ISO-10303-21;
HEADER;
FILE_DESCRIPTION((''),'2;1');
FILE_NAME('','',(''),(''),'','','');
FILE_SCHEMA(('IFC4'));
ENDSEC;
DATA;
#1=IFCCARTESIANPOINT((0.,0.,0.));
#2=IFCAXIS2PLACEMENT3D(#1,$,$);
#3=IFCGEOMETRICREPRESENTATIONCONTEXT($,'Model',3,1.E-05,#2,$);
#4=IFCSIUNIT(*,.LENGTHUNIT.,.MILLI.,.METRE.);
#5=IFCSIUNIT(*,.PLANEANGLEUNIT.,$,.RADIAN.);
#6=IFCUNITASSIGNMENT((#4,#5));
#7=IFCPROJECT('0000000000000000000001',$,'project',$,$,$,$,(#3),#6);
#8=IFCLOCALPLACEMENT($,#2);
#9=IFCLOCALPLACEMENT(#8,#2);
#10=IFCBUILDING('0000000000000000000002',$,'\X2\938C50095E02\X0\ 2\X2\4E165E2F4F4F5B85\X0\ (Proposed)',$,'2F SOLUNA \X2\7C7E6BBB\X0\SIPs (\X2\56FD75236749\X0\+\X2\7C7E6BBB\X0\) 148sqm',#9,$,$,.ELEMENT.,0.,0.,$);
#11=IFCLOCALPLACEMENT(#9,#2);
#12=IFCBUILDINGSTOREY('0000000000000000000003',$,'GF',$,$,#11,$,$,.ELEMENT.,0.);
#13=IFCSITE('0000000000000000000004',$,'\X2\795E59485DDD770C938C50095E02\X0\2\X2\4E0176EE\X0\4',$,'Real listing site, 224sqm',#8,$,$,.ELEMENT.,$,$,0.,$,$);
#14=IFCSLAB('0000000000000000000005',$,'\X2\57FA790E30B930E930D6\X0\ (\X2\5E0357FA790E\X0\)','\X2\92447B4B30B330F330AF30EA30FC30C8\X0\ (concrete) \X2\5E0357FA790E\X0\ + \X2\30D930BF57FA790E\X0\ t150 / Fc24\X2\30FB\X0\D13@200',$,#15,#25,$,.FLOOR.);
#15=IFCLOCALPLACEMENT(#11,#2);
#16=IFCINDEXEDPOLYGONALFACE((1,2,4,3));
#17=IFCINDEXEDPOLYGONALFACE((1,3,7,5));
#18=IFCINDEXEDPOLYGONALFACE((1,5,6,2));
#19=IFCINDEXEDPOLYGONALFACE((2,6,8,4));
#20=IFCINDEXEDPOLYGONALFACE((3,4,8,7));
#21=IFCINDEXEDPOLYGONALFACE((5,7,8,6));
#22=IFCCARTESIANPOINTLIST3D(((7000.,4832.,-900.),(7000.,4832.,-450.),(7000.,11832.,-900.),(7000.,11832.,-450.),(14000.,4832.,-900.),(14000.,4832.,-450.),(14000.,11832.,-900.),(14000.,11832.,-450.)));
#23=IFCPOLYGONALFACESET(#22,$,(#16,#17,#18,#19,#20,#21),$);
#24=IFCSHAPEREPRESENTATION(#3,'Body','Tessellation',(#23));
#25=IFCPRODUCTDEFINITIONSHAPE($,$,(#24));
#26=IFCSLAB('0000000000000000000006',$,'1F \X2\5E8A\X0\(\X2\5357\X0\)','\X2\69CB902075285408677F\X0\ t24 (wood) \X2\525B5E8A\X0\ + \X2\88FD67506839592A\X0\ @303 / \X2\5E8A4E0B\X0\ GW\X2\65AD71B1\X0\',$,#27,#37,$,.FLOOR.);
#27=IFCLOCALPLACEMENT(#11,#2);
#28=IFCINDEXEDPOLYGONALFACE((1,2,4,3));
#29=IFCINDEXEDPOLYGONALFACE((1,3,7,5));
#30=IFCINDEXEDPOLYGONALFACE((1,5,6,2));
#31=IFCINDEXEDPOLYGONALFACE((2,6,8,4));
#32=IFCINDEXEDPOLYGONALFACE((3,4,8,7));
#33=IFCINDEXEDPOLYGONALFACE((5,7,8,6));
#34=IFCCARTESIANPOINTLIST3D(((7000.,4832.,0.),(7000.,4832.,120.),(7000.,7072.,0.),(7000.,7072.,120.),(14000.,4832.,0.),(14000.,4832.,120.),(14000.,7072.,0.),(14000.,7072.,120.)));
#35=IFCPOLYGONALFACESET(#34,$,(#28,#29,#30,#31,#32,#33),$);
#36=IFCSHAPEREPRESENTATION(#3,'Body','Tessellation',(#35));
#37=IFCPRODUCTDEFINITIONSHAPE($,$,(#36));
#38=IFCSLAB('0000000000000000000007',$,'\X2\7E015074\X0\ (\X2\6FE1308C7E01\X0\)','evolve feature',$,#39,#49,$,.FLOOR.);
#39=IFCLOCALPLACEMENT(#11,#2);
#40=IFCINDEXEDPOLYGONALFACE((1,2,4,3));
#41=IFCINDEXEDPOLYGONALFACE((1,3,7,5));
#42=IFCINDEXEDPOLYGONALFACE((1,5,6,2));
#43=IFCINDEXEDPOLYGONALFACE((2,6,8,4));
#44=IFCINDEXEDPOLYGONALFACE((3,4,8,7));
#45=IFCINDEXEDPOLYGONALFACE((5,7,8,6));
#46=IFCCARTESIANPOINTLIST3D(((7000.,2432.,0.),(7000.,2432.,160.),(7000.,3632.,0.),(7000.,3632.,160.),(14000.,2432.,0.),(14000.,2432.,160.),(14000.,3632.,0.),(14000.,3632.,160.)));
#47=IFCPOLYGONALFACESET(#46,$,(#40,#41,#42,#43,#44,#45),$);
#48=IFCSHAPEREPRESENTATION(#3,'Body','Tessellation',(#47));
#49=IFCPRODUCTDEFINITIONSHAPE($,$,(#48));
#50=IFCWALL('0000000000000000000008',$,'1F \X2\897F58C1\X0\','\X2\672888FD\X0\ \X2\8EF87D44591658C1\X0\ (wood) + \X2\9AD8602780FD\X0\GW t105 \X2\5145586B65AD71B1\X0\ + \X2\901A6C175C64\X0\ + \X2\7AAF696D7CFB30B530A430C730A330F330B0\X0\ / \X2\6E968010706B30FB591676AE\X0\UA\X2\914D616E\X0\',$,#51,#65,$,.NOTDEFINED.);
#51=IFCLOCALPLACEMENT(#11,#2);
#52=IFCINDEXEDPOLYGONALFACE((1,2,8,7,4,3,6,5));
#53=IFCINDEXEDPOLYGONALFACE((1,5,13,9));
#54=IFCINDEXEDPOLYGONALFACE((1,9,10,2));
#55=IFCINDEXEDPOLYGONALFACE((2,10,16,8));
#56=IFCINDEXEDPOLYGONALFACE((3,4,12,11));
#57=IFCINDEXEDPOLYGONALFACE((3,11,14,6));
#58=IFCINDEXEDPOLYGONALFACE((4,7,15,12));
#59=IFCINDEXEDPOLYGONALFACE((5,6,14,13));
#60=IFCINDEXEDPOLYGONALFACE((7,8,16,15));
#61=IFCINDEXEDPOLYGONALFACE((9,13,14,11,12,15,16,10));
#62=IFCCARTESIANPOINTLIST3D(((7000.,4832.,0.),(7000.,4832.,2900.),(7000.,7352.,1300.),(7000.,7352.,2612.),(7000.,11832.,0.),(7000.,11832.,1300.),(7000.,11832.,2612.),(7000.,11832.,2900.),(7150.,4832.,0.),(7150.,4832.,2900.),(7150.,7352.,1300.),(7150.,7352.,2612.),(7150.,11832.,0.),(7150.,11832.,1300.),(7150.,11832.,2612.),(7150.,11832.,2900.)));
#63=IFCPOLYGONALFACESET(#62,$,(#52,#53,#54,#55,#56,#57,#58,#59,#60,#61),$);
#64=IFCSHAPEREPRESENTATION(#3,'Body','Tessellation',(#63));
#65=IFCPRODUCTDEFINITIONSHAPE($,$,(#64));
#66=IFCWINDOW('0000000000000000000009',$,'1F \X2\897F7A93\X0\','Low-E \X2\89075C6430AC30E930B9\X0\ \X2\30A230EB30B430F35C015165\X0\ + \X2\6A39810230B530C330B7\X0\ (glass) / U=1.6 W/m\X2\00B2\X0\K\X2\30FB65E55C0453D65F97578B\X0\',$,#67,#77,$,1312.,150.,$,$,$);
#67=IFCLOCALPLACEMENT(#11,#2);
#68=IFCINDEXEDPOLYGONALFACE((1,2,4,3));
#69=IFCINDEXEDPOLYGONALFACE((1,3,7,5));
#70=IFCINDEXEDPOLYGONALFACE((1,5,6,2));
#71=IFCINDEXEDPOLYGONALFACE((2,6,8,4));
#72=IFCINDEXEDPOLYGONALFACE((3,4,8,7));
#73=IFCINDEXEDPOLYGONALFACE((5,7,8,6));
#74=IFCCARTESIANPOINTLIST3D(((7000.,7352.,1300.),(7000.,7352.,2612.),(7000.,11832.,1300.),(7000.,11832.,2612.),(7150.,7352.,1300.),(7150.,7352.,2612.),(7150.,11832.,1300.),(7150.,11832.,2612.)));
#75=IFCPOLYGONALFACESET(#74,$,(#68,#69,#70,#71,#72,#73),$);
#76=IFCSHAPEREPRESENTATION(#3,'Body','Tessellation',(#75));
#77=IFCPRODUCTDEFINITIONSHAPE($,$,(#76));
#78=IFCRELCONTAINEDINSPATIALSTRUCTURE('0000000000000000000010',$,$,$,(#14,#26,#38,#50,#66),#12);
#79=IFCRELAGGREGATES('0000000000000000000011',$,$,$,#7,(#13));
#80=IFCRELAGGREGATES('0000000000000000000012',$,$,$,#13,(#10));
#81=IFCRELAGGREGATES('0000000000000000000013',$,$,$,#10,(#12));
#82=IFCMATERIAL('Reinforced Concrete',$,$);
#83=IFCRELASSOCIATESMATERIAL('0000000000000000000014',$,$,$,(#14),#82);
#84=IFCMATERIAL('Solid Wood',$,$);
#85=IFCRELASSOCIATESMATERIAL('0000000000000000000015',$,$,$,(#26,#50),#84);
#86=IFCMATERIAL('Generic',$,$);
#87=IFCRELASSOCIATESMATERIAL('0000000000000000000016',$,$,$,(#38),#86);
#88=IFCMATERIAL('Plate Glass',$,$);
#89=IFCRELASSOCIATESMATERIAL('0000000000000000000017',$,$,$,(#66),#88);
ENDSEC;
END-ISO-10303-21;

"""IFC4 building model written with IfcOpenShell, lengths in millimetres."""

from ifc_helpers import new_model, si_unit, frame, frame_2d, origin, place, context, project, spatial, rectangle, extrude, material, element, fill, save


model = new_model("IFC4")

# Units and contexts
model_context = context("Model", 3, precision=1e-05, world=origin())
ifc_project = project(units=[si_unit("LENGTHUNIT", "METRE", prefix="MILLI"), si_unit("PLANEANGLEUNIT", "RADIAN")], contexts=[model_context])

# Site, building, storey
site_placement = place(None, origin())
site = spatial("IfcSite", under=ifc_project, at=site_placement, Name="神奈川県鎌倉市2丁目4", ObjectType="Real listing site, 224sqm", CompositionType="ELEMENT", RefElevation=0.0)
building_placement = place(site_placement, origin())
building = spatial("IfcBuilding", under=site, at=building_placement, Name="鎌倉市 2世帯住宅 (Proposed)", ObjectType="2F SOLUNA 籾殻SIPs (国産杉+籾殻) 148sqm", CompositionType="ELEMENT", ElevationOfRefHeight=0.0, ElevationOfTerrain=0.0)
storey_placement = place(building_placement, origin())
storey = spatial("IfcBuildingStorey", under=building, at=storey_placement, Name="GF", CompositionType="ELEMENT", Elevation=0.0)

# Slabs
ifc_material_1 = material(Name="Reinforced Concrete")
slab_1_placement = place(storey_placement, frame((3500.0, 2416.0, -450.0)))
element("IfcSlab", 1, at=slab_1_placement, inside=storey, material=ifc_material_1, Name="基礎スラブ (布基礎)", Description="鉄筋コンクリート (concrete) 布基礎 + ベタ基礎 t150 / Fc24・D13@200", PredefinedType="FLOOR", context=model_context, shape_type="SweptSolid", body=[
    extrude(rectangle(XDim=7000.0, YDim=7000.0, at=frame_2d((3500.0, 3500.0))), frame((3500.0, 2416.0, -450.0)), (0.0, 0.0, 1.0), 450.0),
])
ifc_material_2 = material(Name="Solid Wood")
slab_2_placement = place(storey_placement, frame((3500.0, 2416.0, 0.0)))
element("IfcSlab", 2, at=slab_2_placement, inside=storey, material=ifc_material_2, Name="1F 床(南)", Description="構造用合板 t24 (wood) 剛床 + 製材根太 @303 / 床下 GW断熱", PredefinedType="FLOOR", context=model_context, shape_type="SweptSolid", body=[
    extrude(rectangle(XDim=7000.0, YDim=2240.0, at=frame_2d((3500.0, 1120.0))), frame((3500.0, 2416.0, 0.0)), (0.0, 0.0, 1.0), 120.0),
])
ifc_material_3 = material(Name="Generic")
slab_3_placement = place(storey_placement, frame((3500.0, 1216.0, 0.0)))
element("IfcSlab", 3, at=slab_3_placement, inside=storey, material=ifc_material_3, Name="縁側 (濡れ縁)", Description="evolve feature", PredefinedType="FLOOR", context=model_context, shape_type="SweptSolid", body=[
    extrude(rectangle(XDim=7000.0, YDim=1200.0, at=frame_2d((3500.0, 600.0))), frame((3500.0, 1216.0, 0.0)), (0.0, 0.0, 1.0), 160.0),
])

# Shared definitions
ifc_material_4 = material(Name="Plate Glass")

# Wall, opening, window
wall_1_placement = place(storey_placement, frame((3500.0, 2416.0, 0.0)))
wall_1 = element("IfcWall", 4, at=wall_1_placement, inside=storey, material=ifc_material_2, Name="1F 西壁", Description="木製 軸組外壁 (wood) + 高性能GW t105 充填断熱 + 通気層 + 窯業系サイディング / 準耐火・外皮UA配慮", PredefinedType="NOTDEFINED", context=model_context, shape_type="SweptSolid", body=[
    extrude(rectangle(XDim=150.0, YDim=7000.0, at=frame_2d((75.0, 3500.0))), frame((3500.0, 2416.0, 0.0)), (0.0, 0.0, 1.0), 2900.0),
])
opening_1_placement = place(storey_placement, frame((3500.0, 3676.0, 650.0)))
opening_1 = element("IfcOpeningElement", 5, at=opening_1_placement, cuts=wall_1, PredefinedType="NOTDEFINED", context=model_context, shape_type="SweptSolid", body=[
    extrude(rectangle(XDim=150.0, YDim=4480.0, at=frame_2d((75.0, 2240.0))), frame((3500.0, 3676.0, 650.0)), (0.0, 0.0, 1.0), 1312.0),
])
window_1_placement = place(storey_placement, frame((3500.0, 3676.0, 650.0)))
window_1 = element("IfcWindow", 6, at=window_1_placement, inside=storey, material=ifc_material_4, Name="1F 西窓", Description="Low-E 複層ガラス アルゴン封入 + 樹脂サッシ (glass) / U=1.6 W/m²K・日射取得型", OverallHeight=1312.0, OverallWidth=150.0, context=model_context, shape_type="SweptSolid", body=[
    extrude(rectangle(XDim=150.0, YDim=4480.0, at=frame_2d((75.0, 2240.0))), frame((3500.0, 3676.0, 650.0)), (0.0, 0.0, 1.0), 1312.0),
])
fill(opening_1, window_1)

save(model, "model.ifc")
